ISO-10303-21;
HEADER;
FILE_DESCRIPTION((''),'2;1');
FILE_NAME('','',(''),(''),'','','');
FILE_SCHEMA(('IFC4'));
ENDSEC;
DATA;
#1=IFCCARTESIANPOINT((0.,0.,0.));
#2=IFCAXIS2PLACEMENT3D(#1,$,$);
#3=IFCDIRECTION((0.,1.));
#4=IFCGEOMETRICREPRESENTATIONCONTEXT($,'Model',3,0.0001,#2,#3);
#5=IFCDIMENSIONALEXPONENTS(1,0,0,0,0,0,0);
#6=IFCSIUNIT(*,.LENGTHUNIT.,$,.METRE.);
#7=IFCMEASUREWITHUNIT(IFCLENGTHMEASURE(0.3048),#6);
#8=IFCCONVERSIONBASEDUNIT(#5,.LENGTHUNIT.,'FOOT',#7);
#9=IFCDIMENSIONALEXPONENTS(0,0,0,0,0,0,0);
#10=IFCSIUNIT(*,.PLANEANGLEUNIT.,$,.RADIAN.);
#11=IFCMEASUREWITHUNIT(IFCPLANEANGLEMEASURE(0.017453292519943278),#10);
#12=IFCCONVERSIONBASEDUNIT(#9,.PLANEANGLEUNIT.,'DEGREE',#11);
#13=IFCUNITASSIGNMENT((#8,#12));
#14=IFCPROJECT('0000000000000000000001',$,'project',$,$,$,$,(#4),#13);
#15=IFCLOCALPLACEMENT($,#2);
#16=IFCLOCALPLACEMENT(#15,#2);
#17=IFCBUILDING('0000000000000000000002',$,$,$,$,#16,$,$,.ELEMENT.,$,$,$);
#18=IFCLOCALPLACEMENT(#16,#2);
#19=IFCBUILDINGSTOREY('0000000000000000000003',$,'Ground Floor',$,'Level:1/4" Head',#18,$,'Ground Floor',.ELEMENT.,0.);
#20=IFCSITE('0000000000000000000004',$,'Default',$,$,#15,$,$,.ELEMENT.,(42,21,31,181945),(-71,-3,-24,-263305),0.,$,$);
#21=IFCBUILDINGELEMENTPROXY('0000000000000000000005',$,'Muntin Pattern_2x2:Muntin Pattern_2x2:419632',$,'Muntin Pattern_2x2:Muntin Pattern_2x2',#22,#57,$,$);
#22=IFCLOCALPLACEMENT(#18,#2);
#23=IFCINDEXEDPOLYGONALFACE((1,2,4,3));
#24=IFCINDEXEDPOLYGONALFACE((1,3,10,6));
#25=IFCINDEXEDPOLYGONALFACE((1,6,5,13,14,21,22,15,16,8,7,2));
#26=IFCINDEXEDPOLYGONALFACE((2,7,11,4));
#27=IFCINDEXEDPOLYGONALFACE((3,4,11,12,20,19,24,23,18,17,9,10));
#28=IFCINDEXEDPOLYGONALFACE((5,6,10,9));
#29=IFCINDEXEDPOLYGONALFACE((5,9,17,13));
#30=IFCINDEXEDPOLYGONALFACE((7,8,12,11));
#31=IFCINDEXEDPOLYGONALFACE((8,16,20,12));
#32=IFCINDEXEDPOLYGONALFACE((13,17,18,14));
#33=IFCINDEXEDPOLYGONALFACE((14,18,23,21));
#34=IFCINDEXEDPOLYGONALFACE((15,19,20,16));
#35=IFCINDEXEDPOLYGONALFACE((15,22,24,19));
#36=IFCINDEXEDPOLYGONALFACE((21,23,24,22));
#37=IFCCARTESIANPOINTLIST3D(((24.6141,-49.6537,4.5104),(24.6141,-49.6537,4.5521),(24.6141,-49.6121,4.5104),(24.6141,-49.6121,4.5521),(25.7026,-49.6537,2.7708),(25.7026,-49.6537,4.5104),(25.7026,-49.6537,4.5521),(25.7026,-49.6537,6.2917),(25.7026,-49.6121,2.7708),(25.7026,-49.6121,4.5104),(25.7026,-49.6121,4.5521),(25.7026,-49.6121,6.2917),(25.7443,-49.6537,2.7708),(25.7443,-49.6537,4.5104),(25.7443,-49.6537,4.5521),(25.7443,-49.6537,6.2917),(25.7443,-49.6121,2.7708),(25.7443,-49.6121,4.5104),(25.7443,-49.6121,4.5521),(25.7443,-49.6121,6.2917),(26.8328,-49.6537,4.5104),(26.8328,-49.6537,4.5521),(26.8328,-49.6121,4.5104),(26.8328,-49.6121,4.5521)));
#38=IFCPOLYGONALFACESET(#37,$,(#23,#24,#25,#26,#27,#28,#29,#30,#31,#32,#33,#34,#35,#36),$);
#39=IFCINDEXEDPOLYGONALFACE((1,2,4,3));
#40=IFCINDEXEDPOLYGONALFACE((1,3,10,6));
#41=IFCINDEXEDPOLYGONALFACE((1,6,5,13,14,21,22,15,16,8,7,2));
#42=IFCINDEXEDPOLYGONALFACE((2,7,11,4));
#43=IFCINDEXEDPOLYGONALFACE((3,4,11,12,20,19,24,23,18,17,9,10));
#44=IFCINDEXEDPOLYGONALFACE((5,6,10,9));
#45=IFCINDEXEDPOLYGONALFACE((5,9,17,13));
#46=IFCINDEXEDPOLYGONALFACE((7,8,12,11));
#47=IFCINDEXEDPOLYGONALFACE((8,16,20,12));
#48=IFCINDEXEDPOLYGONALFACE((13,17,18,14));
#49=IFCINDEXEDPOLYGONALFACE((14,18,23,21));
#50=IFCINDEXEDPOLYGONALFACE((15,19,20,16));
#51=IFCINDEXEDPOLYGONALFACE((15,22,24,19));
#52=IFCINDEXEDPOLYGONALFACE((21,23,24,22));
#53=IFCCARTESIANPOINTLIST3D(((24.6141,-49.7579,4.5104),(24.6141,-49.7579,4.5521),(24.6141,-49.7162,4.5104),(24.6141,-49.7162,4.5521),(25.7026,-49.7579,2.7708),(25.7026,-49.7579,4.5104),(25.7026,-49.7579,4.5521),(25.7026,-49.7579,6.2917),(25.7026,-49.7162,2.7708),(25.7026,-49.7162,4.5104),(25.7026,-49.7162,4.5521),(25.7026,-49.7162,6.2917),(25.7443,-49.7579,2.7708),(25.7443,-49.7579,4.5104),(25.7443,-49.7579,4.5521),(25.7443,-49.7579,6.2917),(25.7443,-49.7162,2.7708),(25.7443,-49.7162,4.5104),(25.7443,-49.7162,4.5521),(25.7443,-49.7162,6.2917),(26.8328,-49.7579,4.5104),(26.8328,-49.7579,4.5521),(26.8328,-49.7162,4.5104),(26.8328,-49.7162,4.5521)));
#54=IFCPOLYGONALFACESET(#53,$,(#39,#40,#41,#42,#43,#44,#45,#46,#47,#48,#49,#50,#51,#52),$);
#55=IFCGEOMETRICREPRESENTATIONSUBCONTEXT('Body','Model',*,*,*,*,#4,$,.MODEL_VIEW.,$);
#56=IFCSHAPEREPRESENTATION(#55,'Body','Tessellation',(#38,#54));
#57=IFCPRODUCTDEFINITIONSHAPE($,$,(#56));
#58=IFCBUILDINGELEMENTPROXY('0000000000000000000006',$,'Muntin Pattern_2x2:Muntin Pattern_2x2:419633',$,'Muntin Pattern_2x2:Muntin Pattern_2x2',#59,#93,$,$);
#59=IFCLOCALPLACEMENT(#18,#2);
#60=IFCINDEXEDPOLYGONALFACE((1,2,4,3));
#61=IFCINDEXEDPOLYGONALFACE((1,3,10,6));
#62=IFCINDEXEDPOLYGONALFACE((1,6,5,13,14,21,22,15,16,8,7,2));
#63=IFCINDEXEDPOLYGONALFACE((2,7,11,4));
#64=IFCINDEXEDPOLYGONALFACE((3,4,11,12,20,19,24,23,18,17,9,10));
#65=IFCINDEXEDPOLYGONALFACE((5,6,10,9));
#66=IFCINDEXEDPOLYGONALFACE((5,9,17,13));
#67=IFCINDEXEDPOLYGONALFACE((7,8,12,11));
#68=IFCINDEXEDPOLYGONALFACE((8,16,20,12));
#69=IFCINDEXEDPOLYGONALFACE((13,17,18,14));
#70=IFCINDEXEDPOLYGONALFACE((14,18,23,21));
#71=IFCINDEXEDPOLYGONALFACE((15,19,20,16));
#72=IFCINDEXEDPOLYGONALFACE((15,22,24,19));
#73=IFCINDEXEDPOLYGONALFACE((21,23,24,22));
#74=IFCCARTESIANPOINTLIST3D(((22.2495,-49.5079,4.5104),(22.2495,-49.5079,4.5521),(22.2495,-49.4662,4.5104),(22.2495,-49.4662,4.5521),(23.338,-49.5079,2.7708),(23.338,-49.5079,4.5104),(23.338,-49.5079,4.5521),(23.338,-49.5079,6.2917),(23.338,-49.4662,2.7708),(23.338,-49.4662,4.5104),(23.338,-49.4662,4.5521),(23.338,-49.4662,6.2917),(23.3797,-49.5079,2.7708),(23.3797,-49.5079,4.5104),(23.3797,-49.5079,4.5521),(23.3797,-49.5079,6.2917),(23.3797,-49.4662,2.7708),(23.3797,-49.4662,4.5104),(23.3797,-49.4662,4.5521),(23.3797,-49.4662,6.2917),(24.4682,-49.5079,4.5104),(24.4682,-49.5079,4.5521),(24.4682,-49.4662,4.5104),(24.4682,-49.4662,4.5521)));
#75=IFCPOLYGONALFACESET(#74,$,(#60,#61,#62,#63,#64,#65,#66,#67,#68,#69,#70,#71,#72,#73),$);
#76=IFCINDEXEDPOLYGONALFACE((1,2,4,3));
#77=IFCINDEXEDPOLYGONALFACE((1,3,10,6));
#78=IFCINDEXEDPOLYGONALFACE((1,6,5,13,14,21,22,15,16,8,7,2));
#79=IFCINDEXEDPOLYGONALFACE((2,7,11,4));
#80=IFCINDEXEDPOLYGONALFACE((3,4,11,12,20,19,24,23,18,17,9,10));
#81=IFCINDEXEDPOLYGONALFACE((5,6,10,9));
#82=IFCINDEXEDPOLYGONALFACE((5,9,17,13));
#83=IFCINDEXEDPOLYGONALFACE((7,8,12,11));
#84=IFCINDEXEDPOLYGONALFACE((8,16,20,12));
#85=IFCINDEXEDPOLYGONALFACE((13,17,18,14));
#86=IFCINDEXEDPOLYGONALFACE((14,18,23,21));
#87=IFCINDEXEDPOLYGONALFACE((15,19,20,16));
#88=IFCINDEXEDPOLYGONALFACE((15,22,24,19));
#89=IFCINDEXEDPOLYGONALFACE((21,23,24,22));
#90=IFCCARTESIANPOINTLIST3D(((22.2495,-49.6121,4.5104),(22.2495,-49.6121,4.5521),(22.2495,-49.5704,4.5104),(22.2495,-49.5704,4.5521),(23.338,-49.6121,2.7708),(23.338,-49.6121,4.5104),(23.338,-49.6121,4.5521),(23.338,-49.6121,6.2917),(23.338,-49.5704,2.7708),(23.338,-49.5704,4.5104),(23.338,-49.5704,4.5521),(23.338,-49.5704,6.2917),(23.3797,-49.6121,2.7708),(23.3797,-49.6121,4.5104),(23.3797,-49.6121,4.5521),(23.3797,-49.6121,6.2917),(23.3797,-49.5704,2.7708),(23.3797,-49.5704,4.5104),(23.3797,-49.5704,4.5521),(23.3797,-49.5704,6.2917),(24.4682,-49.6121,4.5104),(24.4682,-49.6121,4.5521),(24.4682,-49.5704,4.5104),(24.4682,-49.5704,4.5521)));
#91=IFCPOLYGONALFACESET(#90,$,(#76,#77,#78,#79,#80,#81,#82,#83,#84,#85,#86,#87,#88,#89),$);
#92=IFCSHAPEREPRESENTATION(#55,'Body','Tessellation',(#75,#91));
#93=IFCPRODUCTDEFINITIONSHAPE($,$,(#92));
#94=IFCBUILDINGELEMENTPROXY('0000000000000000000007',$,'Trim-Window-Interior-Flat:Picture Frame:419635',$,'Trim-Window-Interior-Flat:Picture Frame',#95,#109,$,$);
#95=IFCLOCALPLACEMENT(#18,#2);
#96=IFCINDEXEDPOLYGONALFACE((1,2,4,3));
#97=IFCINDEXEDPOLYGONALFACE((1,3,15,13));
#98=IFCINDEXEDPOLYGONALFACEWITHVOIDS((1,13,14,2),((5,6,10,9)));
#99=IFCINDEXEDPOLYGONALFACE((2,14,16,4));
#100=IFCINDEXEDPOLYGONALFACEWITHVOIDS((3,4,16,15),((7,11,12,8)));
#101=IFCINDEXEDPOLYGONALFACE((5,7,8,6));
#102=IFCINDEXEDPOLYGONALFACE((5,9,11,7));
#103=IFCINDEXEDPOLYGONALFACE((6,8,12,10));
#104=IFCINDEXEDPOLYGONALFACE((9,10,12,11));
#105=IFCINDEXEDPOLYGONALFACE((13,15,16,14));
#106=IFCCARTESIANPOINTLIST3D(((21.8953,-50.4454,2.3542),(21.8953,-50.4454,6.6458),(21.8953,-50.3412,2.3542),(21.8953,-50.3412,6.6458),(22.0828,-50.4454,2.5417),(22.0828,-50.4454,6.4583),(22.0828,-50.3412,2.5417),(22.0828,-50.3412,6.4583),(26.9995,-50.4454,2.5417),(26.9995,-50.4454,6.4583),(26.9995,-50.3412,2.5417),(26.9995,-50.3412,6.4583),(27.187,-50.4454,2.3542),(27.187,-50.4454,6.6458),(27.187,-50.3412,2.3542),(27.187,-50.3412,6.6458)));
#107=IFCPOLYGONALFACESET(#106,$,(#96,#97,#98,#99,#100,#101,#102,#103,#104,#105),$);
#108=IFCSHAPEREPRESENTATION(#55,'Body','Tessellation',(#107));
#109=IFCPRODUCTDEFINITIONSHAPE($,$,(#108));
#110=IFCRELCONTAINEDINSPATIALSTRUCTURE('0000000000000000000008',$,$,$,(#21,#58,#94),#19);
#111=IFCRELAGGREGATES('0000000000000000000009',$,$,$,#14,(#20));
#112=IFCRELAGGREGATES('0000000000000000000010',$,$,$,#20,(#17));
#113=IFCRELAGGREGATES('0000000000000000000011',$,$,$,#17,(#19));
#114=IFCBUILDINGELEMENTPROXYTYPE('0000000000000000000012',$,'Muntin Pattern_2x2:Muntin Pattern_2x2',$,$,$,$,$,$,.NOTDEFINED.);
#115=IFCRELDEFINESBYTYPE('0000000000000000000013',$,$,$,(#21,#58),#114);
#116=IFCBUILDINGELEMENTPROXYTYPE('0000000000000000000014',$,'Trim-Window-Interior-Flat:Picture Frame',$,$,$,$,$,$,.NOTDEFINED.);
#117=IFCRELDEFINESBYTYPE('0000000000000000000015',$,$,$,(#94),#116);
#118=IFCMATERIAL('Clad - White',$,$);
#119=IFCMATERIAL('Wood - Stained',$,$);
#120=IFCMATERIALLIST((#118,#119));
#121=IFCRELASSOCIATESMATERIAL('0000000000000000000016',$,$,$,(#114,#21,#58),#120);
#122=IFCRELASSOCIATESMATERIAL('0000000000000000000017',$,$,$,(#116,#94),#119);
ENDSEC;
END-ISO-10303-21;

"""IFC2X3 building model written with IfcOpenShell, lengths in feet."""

from ifc_helpers import new_model, entity, si_unit, converted_unit, direction, frame, origin, place, context, subcontext, project, spatial, polyline, outline, extrude, source, transform, mapped, material, material_list, type_object, type_shapes, element, save


model = new_model("IFC2X3")

# Units and contexts
model_context = context("Model", 3, precision=0.0001, world=origin(), true_north=direction((0.0, 1.0)))
body_context = subcontext(model_context, "Body", "Model", "MODEL_VIEW")
ifc_project = project(units=[converted_unit("LENGTHUNIT", "FOOT", entity("IfcLengthMeasure", 0.3048), si_unit("LENGTHUNIT", "METRE"), dimensions=[1, 0, 0, 0, 0, 0, 0]), converted_unit("PLANEANGLEUNIT", "DEGREE", entity("IfcPlaneAngleMeasure", 0.017453292519943278), si_unit("PLANEANGLEUNIT", "RADIAN"), dimensions=[0, 0, 0, 0, 0, 0, 0])], contexts=[model_context])

# Site, building, storey
site_placement = place(None, origin())
site = spatial("IfcSite", under=ifc_project, at=site_placement, Name="Default", CompositionType="ELEMENT", RefLatitude=(42, 21, 31, 181945), RefLongitude=(-71, -3, -24, -263305), RefElevation=0.0)
building_placement = place(site_placement, origin())
building = spatial("IfcBuilding", under=site, at=building_placement, CompositionType="ELEMENT")
storey_placement = place(building_placement, origin())
storey = spatial("IfcBuildingStorey", under=building, at=storey_placement, Name="Ground Floor", ObjectType="Level:1/4\" Head", LongName="Ground Floor", CompositionType="ELEMENT", Elevation=0.0)

# Building element proxies
ifc_material_1 = material(Name="Clad - White")
ifc_material_2 = material(Name="Wood - Stained")
ifc_material_list_1 = material_list([ifc_material_1, ifc_material_2])
building_element_proxy_type_1 = type_object("IfcBuildingElementProxyType", Name="Muntin Pattern_2x2:Muntin Pattern_2x2", PredefinedType="NOTDEFINED", material=ifc_material_list_1)
shared_shape_1 = source(origin(), body_context, "Body", "SweptSolid", [
    extrude(outline(polyline([(0.0208, -0.0208), (1.7604, -0.0208), (1.7604, 0.0208), (0.0208, 0.0208), (0.0208, 1.1094), (-0.0208, 1.1094), (-0.0208, 0.0208), (-1.7604, 0.0208), (-1.7604, -0.0208), (-0.0208, -0.0208), (-0.0208, -1.1094), (0.0208, -1.1094), (0.0208, -0.0208)])), frame((0.0, 0.0313, 1.7604), z_axis=(0.0, 1.0, 0.0), x_axis=(0.0, 0.0, 1.0)), (0.0, 0.0, 1.0), 0.0417),
    extrude(outline(polyline([(0.0208, -0.0208), (1.7604, -0.0208), (1.7604, 0.0208), (0.0208, 0.0208), (0.0208, 1.1094), (-0.0208, 1.1094), (-0.0208, 0.0208), (-1.7604, 0.0208), (-1.7604, -0.0208), (-0.0208, -0.0208), (-0.0208, -1.1094), (0.0208, -1.1094), (0.0208, -0.0208)])), frame((0.0, -0.0729, 1.7604), z_axis=(0.0, 1.0, 0.0), x_axis=(0.0, 0.0, 1.0)), (0.0, 0.0, 1.0), 0.0417),
])
type_shapes(building_element_proxy_type_1, [shared_shape_1])
for number, where, name in (
    (1, (25.7234, -49.685, 2.7708), "Muntin Pattern_2x2:Muntin Pattern_2x2:419632"),
    (2, (23.3589, -49.5392, 2.7708), "Muntin Pattern_2x2:Muntin Pattern_2x2:419633"),
):
    element("IfcBuildingElementProxy", number, at=place(storey_placement, frame(where)), inside=storey, type_object=building_element_proxy_type_1, material=ifc_material_list_1, Name=name, ObjectType="Muntin Pattern_2x2:Muntin Pattern_2x2", context=body_context, shape_type="MappedRepresentation", body=[
        mapped(shared_shape_1, transform((0.0, 0.0, 0.0), scale=1.0)),
    ])
building_element_proxy_type_2 = type_object("IfcBuildingElementProxyType", Name="Trim-Window-Interior-Flat:Picture Frame", PredefinedType="NOTDEFINED", material=ifc_material_2)
shared_shape_2 = source(origin(), body_context, "Body", "SweptSolid", [
    extrude(outline(polyline([(-2.6458, -2.1458), (2.6458, -2.1458), (2.6458, 2.1458), (-2.6458, 2.1458), (-2.6458, -2.1458)]), holes=[polyline([(-2.4583, -1.9583), (-2.4583, 1.9583), (2.4583, 1.9583), (2.4583, -1.9583), (-2.4583, -1.9583)])]), frame((0.0, -2.0, 0.0), z_axis=(0.0, 0.0, 1.0), x_axis=(-1.0, 0.0, 0.0)), (0.0, 0.0, 1.0), 0.1042),
])
type_shapes(building_element_proxy_type_2, [shared_shape_2])
proxy_1_placement = place(storey_placement, frame((24.5411, -50.3412, 6.5), z_axis=(0.0, -1.0, 0.0), x_axis=(1.0, 0.0, 0.0)))
element("IfcBuildingElementProxy", 3, at=proxy_1_placement, inside=storey, type_object=building_element_proxy_type_2, material=ifc_material_2, Name="Trim-Window-Interior-Flat:Picture Frame:419635", ObjectType="Trim-Window-Interior-Flat:Picture Frame", context=body_context, shape_type="MappedRepresentation", body=[
    mapped(shared_shape_2, transform((0.0, 0.0, 0.0), scale=1.0)),
])

save(model, "model.ifc")
